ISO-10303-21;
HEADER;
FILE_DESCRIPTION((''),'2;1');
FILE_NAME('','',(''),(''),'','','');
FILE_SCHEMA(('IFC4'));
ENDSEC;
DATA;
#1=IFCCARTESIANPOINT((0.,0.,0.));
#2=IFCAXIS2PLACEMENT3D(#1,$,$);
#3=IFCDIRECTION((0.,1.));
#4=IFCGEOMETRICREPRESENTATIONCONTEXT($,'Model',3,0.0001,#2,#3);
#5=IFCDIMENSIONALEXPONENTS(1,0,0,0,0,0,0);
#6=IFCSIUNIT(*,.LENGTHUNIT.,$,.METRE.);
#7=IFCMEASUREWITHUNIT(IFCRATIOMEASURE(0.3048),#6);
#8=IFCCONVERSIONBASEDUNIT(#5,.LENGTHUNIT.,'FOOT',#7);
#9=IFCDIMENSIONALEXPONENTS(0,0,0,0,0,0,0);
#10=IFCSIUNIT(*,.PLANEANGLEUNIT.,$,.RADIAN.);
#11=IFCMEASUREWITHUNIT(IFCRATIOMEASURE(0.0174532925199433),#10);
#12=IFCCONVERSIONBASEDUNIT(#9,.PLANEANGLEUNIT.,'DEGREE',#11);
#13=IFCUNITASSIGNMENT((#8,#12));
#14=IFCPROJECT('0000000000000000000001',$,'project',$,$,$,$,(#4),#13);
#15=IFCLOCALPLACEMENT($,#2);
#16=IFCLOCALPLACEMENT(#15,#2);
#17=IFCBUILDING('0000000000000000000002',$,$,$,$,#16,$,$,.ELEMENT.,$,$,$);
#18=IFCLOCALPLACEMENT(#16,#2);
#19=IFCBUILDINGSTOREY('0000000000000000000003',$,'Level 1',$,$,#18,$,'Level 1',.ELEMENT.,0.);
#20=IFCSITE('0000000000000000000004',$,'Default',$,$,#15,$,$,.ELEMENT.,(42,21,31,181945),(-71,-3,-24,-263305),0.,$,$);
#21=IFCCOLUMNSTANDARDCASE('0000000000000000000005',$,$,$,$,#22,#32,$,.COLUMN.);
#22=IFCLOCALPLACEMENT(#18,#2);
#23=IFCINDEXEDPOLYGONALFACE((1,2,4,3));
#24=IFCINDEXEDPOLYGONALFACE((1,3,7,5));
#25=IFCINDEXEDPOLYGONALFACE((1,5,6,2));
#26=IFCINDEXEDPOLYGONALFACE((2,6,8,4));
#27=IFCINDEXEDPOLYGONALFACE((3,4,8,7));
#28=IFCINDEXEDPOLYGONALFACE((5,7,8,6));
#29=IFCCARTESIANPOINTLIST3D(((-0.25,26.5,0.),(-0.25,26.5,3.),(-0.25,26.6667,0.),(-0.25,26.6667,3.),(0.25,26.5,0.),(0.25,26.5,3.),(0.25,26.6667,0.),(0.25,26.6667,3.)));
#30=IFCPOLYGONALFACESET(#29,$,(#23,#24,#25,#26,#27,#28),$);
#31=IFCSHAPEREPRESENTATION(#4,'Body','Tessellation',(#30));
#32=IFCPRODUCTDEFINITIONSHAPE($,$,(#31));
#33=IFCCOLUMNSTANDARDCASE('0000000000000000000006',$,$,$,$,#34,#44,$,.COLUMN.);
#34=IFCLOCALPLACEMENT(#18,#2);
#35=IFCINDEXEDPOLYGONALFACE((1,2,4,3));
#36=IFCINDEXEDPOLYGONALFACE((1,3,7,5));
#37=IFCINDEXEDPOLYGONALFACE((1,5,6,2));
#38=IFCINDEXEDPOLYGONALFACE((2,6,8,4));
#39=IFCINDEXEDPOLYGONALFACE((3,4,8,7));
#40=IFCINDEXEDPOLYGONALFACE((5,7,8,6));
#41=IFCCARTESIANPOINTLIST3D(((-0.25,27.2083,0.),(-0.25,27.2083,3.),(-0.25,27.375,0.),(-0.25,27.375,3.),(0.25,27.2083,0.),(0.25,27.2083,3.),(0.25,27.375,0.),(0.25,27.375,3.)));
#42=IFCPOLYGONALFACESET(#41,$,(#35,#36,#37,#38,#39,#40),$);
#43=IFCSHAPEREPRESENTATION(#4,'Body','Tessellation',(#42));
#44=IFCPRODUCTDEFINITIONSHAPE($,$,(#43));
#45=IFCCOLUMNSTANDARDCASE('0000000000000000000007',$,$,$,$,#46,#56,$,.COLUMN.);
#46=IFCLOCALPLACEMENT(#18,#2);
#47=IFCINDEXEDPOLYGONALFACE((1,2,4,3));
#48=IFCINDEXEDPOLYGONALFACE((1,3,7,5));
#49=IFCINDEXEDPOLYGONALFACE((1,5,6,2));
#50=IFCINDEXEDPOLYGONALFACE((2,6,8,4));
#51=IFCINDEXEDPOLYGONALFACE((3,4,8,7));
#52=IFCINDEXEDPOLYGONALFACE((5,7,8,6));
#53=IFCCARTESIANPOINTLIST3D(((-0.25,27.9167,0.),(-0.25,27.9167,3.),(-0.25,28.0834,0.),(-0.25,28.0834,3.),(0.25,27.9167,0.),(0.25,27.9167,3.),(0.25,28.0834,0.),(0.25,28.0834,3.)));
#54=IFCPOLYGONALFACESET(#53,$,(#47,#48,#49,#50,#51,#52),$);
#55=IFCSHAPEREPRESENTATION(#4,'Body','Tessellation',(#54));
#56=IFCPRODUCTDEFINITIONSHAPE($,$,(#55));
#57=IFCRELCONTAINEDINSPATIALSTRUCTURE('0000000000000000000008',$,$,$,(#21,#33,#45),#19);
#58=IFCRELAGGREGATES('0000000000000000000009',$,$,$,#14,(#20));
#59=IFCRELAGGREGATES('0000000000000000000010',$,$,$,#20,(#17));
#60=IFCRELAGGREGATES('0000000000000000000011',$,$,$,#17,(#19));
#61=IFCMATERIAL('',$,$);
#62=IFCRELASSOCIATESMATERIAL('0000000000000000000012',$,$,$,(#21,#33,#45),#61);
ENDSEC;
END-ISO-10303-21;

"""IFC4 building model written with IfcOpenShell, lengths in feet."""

from ifc_helpers import new_model, entity, si_unit, converted_unit, direction, frame, origin, place, context, project, spatial, rectangle, extrude, material, element, save


model = new_model("IFC4")

# Units and contexts
model_context = context("Model", 3, precision=0.0001, world=origin(), true_north=direction((0.0, 1.0)))
ifc_project = project(units=[converted_unit("LENGTHUNIT", "FOOT", entity("IfcRatioMeasure", 0.3048), si_unit("LENGTHUNIT", "METRE"), dimensions=[1, 0, 0, 0, 0, 0, 0]), converted_unit("PLANEANGLEUNIT", "DEGREE", entity("IfcRatioMeasure", 0.0174532925199433), si_unit("PLANEANGLEUNIT", "RADIAN"), dimensions=[0, 0, 0, 0, 0, 0, 0])], contexts=[model_context])

# Site, building, storey
site_placement = place(None, origin())
site = spatial("IfcSite", under=ifc_project, at=site_placement, Name="Default", CompositionType="ELEMENT", RefLatitude=(42, 21, 31, 181945), RefLongitude=(-71, -3, -24, -263305), RefElevation=0.0)
building_placement = place(site_placement, origin())
building = spatial("IfcBuilding", under=site, at=building_placement, CompositionType="ELEMENT")
storey_placement = place(building_placement, origin())
storey = spatial("IfcBuildingStorey", under=building, at=storey_placement, Name="Level 1", LongName="Level 1", CompositionType="ELEMENT", Elevation=0.0)

# Columns
placement = place(storey_placement, frame((0.0, -0.25, 0.0), z_axis=(0.0, 0.0, 1.0), x_axis=(0.0, 1.0, 0.0)))
ifc_material_1 = material(Name="")
for number, where, z_axis, x_axis in (
    (1, (26.8334, 0.0, 0.0), (0.0, 0.0, 1.0), (1.0, 0.0, 0.0)),
    (2, (27.5417, 0.0, 0.0), (0.0, 0.0, 1.0), (1.0, 0.0, 0.0)),
    (3, (28.25, 0.0, 0.0), (0.0, 0.0, 1.0), (1.0, 0.0, 0.0)),
):
    element("IfcColumnStandardCase", number, at=place(placement, frame(where, z_axis=z_axis, x_axis=x_axis)), inside=storey, material=ifc_material_1, PredefinedType="COLUMN", context=model_context, shape_type="SweptSolid", body=[
        extrude(rectangle(XDim=0.1667, YDim=0.5), origin(), (0.0, 0.0, 1.0), 3.0),
    ])

save(model, "model.ifc")
